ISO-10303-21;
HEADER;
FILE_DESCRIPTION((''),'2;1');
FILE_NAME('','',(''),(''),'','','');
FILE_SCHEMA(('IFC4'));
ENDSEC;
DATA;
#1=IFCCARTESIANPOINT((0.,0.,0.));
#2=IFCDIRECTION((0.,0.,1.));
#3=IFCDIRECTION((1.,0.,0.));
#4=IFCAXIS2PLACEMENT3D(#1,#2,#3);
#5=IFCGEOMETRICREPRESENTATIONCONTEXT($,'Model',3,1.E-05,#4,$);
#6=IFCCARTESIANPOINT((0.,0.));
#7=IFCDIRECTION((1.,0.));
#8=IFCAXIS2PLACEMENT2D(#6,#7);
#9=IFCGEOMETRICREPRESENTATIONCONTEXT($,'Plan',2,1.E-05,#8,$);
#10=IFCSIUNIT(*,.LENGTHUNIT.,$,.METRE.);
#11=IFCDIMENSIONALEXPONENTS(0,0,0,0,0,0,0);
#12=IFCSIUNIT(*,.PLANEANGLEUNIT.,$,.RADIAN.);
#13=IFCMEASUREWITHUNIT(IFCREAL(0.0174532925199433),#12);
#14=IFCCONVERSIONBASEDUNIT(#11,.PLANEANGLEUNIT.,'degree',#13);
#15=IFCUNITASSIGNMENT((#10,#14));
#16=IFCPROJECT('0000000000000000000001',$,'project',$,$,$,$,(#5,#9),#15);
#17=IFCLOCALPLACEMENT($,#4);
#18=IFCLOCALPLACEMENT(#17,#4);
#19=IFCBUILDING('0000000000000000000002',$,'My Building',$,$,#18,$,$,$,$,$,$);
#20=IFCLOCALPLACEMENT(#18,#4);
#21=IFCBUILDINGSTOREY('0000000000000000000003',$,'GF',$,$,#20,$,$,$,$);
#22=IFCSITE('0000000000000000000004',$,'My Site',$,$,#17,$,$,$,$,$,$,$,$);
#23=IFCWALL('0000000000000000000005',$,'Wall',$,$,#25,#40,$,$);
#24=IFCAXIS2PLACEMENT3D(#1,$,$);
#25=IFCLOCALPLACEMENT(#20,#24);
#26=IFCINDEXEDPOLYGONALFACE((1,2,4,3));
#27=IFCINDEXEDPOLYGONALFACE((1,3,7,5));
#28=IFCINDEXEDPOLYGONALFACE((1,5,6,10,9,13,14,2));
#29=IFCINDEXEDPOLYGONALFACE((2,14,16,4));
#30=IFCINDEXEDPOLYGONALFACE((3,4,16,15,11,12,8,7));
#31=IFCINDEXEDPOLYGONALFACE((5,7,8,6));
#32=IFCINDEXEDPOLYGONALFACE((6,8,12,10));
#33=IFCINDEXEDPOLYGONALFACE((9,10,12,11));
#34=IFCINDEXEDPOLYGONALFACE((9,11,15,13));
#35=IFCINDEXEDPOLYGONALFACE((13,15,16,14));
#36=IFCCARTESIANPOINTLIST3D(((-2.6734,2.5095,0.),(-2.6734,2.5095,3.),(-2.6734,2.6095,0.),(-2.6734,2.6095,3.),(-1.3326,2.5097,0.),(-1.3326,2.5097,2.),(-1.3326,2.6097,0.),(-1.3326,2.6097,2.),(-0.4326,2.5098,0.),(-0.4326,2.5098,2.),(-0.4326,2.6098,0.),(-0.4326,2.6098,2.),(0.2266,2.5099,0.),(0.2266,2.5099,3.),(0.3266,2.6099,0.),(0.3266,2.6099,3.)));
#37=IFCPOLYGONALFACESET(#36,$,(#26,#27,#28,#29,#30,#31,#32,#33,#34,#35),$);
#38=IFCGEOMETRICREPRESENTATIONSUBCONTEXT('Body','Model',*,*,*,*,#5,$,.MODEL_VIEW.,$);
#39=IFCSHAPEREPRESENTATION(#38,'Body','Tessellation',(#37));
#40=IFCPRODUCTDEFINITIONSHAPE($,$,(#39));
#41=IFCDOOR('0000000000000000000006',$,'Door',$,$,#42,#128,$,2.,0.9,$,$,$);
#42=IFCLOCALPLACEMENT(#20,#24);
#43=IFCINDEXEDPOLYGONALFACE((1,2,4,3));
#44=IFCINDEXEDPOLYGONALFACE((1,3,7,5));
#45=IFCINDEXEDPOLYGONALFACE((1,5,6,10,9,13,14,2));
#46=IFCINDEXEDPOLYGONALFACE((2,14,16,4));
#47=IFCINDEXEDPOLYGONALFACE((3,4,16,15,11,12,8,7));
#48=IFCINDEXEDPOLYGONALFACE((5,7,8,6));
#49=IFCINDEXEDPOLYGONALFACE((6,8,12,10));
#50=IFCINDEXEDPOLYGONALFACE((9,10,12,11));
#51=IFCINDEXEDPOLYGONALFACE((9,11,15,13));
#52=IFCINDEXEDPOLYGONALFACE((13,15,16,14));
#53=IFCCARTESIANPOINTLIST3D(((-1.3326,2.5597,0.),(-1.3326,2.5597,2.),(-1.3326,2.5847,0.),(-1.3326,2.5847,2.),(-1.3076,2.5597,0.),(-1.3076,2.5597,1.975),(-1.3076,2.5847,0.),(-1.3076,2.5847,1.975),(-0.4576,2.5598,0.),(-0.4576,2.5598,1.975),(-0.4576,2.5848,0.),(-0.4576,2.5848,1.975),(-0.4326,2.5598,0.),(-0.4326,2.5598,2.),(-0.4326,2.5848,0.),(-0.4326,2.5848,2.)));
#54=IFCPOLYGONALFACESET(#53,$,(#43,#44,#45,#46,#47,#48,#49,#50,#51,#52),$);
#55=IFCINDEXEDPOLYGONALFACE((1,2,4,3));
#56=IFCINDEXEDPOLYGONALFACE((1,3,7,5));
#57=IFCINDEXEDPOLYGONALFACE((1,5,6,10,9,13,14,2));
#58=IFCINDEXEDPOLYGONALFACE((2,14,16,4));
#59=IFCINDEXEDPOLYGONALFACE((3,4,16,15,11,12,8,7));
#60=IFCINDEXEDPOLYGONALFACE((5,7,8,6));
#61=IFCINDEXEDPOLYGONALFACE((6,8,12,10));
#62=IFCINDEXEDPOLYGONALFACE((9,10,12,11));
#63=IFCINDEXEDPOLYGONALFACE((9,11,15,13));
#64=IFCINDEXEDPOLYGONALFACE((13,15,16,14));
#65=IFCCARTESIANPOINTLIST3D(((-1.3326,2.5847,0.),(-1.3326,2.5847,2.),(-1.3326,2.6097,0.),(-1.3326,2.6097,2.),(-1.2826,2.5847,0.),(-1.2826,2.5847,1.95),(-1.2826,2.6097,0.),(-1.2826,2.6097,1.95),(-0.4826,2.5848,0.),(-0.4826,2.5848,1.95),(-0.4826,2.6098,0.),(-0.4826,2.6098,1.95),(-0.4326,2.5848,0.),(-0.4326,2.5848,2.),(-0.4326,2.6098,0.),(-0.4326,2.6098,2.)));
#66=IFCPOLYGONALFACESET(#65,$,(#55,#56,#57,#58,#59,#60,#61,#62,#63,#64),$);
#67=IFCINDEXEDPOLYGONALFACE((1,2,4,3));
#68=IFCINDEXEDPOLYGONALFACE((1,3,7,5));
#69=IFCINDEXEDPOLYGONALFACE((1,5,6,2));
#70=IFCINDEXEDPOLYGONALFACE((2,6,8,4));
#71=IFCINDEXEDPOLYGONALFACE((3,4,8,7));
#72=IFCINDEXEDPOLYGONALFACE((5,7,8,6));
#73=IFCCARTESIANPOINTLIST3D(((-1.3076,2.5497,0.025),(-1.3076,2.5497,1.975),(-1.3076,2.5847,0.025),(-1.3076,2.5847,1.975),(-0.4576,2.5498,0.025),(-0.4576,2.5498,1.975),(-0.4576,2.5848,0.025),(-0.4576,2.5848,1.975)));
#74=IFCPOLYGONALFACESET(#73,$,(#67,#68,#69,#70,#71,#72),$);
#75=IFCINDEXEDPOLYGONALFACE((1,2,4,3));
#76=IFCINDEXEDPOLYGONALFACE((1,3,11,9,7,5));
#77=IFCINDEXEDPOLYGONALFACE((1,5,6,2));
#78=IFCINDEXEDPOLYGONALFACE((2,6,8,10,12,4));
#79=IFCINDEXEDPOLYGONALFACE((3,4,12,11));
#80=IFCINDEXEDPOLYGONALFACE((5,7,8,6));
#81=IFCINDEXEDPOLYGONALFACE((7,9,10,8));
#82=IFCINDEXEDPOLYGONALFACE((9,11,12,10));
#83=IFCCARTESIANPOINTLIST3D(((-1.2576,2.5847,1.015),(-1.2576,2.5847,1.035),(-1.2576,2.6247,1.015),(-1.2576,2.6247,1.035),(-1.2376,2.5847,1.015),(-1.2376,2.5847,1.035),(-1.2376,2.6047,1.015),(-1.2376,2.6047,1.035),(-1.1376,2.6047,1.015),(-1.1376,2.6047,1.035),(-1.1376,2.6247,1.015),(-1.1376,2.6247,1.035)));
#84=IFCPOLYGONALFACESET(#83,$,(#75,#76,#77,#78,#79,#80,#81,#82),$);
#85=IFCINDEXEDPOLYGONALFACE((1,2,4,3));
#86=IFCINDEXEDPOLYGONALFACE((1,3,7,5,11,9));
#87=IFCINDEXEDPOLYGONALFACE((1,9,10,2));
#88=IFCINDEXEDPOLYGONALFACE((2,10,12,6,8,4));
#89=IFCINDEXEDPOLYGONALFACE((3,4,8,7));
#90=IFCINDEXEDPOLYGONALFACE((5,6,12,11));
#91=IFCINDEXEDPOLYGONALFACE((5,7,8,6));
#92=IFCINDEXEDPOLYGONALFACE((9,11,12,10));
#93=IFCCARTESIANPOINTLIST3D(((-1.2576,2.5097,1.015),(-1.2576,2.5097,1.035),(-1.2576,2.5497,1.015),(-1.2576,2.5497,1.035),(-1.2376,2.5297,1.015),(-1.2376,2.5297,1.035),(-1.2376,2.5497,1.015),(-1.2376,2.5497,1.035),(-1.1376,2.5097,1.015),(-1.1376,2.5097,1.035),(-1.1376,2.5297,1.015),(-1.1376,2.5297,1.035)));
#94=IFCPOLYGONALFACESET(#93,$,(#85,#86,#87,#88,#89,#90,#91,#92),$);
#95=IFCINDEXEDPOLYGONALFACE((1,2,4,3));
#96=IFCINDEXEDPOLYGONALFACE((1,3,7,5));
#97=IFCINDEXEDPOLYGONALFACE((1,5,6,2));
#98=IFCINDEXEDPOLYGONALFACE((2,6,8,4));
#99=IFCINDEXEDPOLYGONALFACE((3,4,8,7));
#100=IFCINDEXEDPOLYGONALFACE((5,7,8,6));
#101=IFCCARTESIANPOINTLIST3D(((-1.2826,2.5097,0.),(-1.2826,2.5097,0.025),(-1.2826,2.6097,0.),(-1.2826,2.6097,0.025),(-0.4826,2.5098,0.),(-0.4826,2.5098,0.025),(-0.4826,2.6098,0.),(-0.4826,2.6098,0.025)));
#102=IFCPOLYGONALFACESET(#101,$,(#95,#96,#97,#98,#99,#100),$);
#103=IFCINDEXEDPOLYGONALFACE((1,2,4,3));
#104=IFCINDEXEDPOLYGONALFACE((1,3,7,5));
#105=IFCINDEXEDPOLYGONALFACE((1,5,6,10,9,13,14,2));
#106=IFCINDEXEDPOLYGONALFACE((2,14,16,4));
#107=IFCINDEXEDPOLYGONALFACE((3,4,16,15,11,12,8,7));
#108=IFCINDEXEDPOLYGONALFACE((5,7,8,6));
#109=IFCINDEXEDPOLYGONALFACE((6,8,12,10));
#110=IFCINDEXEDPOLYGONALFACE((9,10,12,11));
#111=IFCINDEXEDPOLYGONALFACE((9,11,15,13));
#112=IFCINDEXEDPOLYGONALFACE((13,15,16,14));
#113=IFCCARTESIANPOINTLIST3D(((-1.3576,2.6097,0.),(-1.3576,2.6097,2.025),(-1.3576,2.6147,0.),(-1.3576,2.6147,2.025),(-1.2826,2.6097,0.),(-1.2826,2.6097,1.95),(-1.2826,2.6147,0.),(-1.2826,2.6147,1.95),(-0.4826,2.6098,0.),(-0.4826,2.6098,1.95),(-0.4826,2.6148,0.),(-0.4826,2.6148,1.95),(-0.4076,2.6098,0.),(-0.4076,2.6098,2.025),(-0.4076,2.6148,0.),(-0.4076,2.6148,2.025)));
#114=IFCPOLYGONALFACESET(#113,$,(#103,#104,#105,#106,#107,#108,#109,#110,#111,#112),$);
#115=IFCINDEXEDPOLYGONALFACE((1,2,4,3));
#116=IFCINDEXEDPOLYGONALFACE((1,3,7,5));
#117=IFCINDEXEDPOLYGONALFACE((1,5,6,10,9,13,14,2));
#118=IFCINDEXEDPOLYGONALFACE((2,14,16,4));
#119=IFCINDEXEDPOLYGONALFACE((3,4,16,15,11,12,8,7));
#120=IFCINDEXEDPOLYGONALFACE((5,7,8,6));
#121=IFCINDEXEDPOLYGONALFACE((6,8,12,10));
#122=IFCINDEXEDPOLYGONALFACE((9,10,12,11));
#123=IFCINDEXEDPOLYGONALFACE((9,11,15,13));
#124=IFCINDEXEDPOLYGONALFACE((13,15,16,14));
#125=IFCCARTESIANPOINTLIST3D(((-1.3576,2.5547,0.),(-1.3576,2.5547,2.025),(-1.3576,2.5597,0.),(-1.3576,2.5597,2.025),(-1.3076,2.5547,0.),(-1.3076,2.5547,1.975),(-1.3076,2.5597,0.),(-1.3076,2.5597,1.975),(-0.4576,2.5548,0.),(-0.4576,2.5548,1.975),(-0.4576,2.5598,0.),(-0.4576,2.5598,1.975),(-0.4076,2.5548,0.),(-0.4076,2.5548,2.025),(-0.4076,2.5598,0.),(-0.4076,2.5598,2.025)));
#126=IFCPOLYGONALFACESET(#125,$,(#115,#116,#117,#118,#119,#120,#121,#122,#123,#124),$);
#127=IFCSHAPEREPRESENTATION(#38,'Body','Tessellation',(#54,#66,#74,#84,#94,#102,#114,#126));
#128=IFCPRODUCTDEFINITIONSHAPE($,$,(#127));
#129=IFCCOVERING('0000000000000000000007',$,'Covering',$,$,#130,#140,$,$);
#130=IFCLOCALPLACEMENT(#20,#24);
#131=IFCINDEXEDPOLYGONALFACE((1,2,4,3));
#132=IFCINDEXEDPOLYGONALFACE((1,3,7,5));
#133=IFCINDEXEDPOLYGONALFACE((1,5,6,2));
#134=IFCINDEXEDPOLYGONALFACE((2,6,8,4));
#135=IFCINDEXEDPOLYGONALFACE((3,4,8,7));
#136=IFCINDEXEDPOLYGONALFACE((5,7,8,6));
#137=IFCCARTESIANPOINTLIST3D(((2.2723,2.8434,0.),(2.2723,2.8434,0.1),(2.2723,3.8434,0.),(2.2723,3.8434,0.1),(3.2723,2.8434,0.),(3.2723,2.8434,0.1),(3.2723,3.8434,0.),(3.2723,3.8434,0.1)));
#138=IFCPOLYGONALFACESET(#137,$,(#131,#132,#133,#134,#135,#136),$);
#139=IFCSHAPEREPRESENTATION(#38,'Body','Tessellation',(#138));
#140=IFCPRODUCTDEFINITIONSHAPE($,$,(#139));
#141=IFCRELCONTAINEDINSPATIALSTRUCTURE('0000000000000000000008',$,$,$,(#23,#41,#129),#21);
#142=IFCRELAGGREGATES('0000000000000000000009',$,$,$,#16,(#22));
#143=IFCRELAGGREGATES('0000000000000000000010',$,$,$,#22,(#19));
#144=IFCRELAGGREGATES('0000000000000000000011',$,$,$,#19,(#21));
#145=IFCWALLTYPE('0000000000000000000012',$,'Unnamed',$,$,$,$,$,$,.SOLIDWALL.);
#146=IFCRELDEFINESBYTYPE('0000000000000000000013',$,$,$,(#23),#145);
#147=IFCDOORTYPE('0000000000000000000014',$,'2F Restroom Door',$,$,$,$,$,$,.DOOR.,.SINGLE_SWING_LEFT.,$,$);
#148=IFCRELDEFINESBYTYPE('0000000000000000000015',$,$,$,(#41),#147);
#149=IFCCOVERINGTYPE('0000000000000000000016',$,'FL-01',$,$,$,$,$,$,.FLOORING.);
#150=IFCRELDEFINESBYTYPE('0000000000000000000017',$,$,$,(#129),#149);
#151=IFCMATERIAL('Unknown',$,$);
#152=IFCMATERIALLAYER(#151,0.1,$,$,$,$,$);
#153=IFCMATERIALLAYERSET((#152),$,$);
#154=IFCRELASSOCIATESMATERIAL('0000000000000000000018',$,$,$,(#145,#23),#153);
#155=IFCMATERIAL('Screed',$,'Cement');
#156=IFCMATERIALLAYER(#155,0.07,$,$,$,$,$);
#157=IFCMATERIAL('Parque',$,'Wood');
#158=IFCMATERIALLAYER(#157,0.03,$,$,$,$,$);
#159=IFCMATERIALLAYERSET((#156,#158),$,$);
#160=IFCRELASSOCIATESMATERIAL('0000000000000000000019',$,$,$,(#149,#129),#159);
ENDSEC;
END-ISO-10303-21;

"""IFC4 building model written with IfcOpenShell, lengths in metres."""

from ifc_helpers import new_model, entity, si_unit, converted_unit, frame, origin_with_axes, origin_2d_with_axis, place, context, subcontext, project, spatial, line, indexed_curve, outline, extrude, shape, source, transform, mapped, material, layer, layer_set, layer_usage, type_object, type_shapes, element, fill, save


model = new_model("IFC4")

# Units and contexts
model_context = context("Model", 3, precision=1e-05, world=origin_with_axes())
plan_context = context("Plan", 2, precision=1e-05, world=origin_2d_with_axis())
body_context_1 = subcontext(model_context, "Body", "Model", "MODEL_VIEW")
body_context_2 = subcontext(plan_context, "Body", "Plan", "PLAN_VIEW")
ifc_project = project(units=[si_unit("LENGTHUNIT", "METRE"), converted_unit("PLANEANGLEUNIT", "degree", entity("IfcReal", 0.0174532925199433), si_unit("PLANEANGLEUNIT", "RADIAN"), dimensions=[0, 0, 0, 0, 0, 0, 0])], contexts=[model_context, plan_context])

# Site, building, storey
site_placement = place(None, origin_with_axes())
site = spatial("IfcSite", under=ifc_project, at=site_placement, Name="My Site")
building_placement = place(site_placement, origin_with_axes())
building = spatial("IfcBuilding", under=site, at=building_placement, Name="My Building")
storey_placement = place(building_placement, origin_with_axes())
storey = spatial("IfcBuildingStorey", under=building, at=storey_placement, Name="GF")

# Shared definitions
ifc_material_1 = material(Name="Unknown")

# Shared definitions
ifc_layer_1 = layer(ifc_material_1, 0.1)
ifc_layer_set_1 = layer_set([ifc_layer_1])
wall_type = type_object("IfcWallType", Name="Unnamed", PredefinedType="SOLIDWALL", material=ifc_layer_set_1)

# Wall, opening, door
ifc_layer_usage_1 = layer_usage(ifc_layer_set_1, "AXIS2", "POSITIVE", 0.0)
wall_1_placement = place(storey_placement, frame((0.3266, 2.6099, 0.0), z_axis=(0.0, 0.0, 1.0), x_axis=(-1.0, -0.00012, 0.0)))
wall_1 = element("IfcWall", 1, at=wall_1_placement, inside=storey, type_object=wall_type, material=ifc_layer_usage_1, Name="Wall", context=body_context_1, shape_type="SweptSolid", body=[
    extrude(outline(indexed_curve([(0.0, 0.0), (0.1, 0.1), (3.0, 0.1), (3.0, 0.0)], segments=[line(1, 2, 3, 4, 1)])), origin_with_axes(), (0.0, 0.0, 1.0), 3.0),
])
shared_shape_1 = source(origin_with_axes(), body_context_1, "Body", "SweptSolid", [
    extrude(outline(indexed_curve([(0.0, 0.0), (0.9, 0.0), (0.9, 2.0), (0.0, 2.0)], segments=[line(1, 2, 3, 4, 1)])), frame((0.0, -0.6, 0.0), z_axis=(0.0, -1.0, 0.0), x_axis=(1.0, 0.0, 0.0)), (0.0, 0.0, -1.0), 1.2),
])
opening_1_placement = place(wall_1_placement, frame((0.7592, 0.0, 0.0), z_axis=(0.0, 0.0, 1.0), x_axis=(1.0, 0.0, 0.0)))
opening_1 = element("IfcOpeningElement", 2, at=opening_1_placement, cuts=wall_1, PredefinedType="OPENING", context=body_context_1, shape_type="MappedRepresentation", body=[
    mapped(shared_shape_1, transform((0.0, 0.0, 0.0), x_axis=(1.0, 0.0, 0.0), y_axis=(0.0, 1.0, 0.0), z_axis=(0.0, 0.0, 1.0), scale=1.0)),
])
door_type_1 = type_object("IfcDoorType", Name="2F Restroom Door", OperationType="SINGLE_SWING_LEFT", PredefinedType="DOOR")
shared_shape_2 = source(origin_with_axes(), body_context_1, "Body", "SweptSolid", [
    extrude(outline(indexed_curve([(0.0, 0.0), (0.0, 2.0), (0.9, 2.0), (0.9, 0.0), (0.875, 0.0), (0.875, 1.975), (0.025, 1.975), (0.025, 0.0)], segments=[line(1, 2, 3, 4, 5, 6, 7, 8, 1)])), frame((0.0, 0.025, 0.0), z_axis=(0.0, -1.0, 0.0), x_axis=(1.0, 0.0, 0.0)), (0.0, 0.0, -1.0), 0.025),
    extrude(outline(indexed_curve([(0.0, 0.0), (0.0, 2.0), (0.9, 2.0), (0.9, 0.0), (0.85, 0.0), (0.85, 1.95), (0.05, 1.95), (0.05, 0.0)], segments=[line(1, 2, 3, 4, 5, 6, 7, 8, 1)])), frame((0.0, 0.0, 0.0), z_axis=(0.0, -1.0, 0.0), x_axis=(1.0, 0.0, 0.0)), (0.0, 0.0, -1.0), 0.025),
    extrude(outline(indexed_curve([(0.0, 0.0), (0.85, 0.0), (0.85, 0.035), (0.0, 0.035)], segments=[line(1, 2, 3, 4, 1)])), frame((0.025, 0.025, 0.025), z_axis=(0.0, 0.0, 1.0), x_axis=(1.0, 0.0, 0.0)), (0.0, 0.0, 1.0), 1.95),
    extrude(outline(indexed_curve([(0.0, 0.0), (0.0, -0.04), (-0.12, -0.04), (-0.12, -0.02), (-0.02, -0.02), (-0.02, 0.0)], segments=[line(1, 2, 3, 4, 5, 6, 1)])), frame((0.825, 0.025, 1.015), z_axis=(0.0, 0.0, 1.0), x_axis=(1.0, 0.0, 0.0)), (0.0, 0.0, 1.0), 0.02),
    extrude(outline(indexed_curve([(0.0, 0.0), (0.0, 0.04), (-0.12, 0.04), (-0.12, 0.02), (-0.02, 0.02), (-0.02, 0.0)], segments=[line(1, 2, 3, 4, 5, 6, 1)])), frame((0.825, 0.06, 1.015), z_axis=(0.0, 0.0, 1.0), x_axis=(1.0, 0.0, 0.0)), (0.0, 0.0, 1.0), 0.02),
    extrude(outline(indexed_curve([(0.0, 0.0), (0.8, 0.0), (0.8, 0.1), (0.0, 0.1)], segments=[line(1, 2, 3, 4, 1)])), frame((0.05, 0.0, 0.0), z_axis=(0.0, 0.0, 1.0), x_axis=(1.0, 0.0, 0.0)), (0.0, 0.0, 1.0), 0.025),
    extrude(outline(indexed_curve([(0.0, 0.0), (0.0, 2.025), (0.95, 2.025), (0.95, 0.0), (0.875, 0.0), (0.875, 1.95), (0.075, 1.95), (0.075, 0.0)], segments=[line(1, 2, 3, 4, 5, 6, 7, 8, 1)])), frame((-0.025, -0.005, 0.0), z_axis=(0.0, -1.0, 0.0), x_axis=(1.0, 0.0, 0.0)), (0.0, 0.0, -1.0), 0.005),
    extrude(outline(indexed_curve([(0.0, 0.0), (0.0, 2.025), (0.95, 2.025), (0.95, 0.0), (0.9, 0.0), (0.9, 1.975), (0.05, 1.975), (0.05, 0.0)], segments=[line(1, 2, 3, 4, 5, 6, 7, 8, 1)])), frame((-0.025, 0.05, 0.0), z_axis=(0.0, -1.0, 0.0), x_axis=(1.0, 0.0, 0.0)), (0.0, 0.0, -1.0), 0.005),
])
shared_shape_3 = source(origin_with_axes(), body_context_2, "Body", "Curve2D", [
    entity("IfcIndexedPolyCurve", entity("IfcCartesianPointList2D", [[0.0, 0.0], [0.0, 0.05], [0.025, 0.05], [0.025, 0.025], [0.05, 0.025], [0.05, 0.0]]), [entity("IfcLineIndex", [1, 2, 3, 4, 5, 6, 1])]),
    entity("IfcIndexedPolyCurve", entity("IfcCartesianPointList2D", [[0.9, 0.0], [0.9, 0.05], [0.875, 0.05], [0.875, 0.025], [0.85, 0.025], [0.85, 0.0]]), [entity("IfcLineIndex", [1, 2, 3, 4, 5, 6, 1])]),
    entity("IfcTrimmedCurve", entity("IfcEllipse", entity("IfcAxis2Placement2D", entity("IfcCartesianPoint", [0.06, 0.05]), entity("IfcDirection", [1.0, 0.0])), 0.815, 0.85), [entity("IfcCartesianPoint", [0.875, 0.05])], [entity("IfcCartesianPoint", [0.06, 0.9])], True, "CARTESIAN"),
    entity("IfcIndexedPolyCurve", entity("IfcCartesianPointList2D", [[0.025, 0.05], [0.06, 0.05], [0.06, 0.9], [0.025, 0.9]]), [entity("IfcLineIndex", [1, 2, 3, 4, 1])]),
])
type_shapes(door_type_1, [shared_shape_2, shared_shape_3])
door_1_placement = place(opening_1_placement, frame((0.0, 0.0, 0.0), z_axis=(0.0, 0.0, 1.0), x_axis=(1.0, 0.0, 0.0)))
door_1 = element("IfcDoor", 3, at=door_1_placement, inside=storey, type_object=door_type_1, Name="Door", OverallHeight=2.0, OverallWidth=0.9, shapes=[
    shape(body_context_1, "Body", "MappedRepresentation", [mapped(shared_shape_2, transform((0.0, 0.0, 0.0), x_axis=(1.0, 0.0, 0.0), y_axis=(0.0, 1.0, 0.0), z_axis=(0.0, 0.0, 1.0), scale=1.0))]),
    shape(body_context_2, "Body", "MappedRepresentation", [mapped(shared_shape_3, transform((0.0, 0.0, 0.0), x_axis=(1.0, 0.0, 0.0), y_axis=(0.0, 1.0, 0.0), z_axis=(0.0, 0.0, 1.0), scale=1.0))]),
])
fill(opening_1, door_1)

# Covering
ifc_material_2 = material(Name="Screed", Category="Cement")
ifc_layer_2 = layer(ifc_material_2, 0.07)
ifc_material_3 = material(Name="Parque", Category="Wood")
ifc_layer_3 = layer(ifc_material_3, 0.03)
ifc_layer_set_2 = layer_set([ifc_layer_2, ifc_layer_3])
ifc_layer_usage_2 = layer_usage(ifc_layer_set_2, "AXIS3", "POSITIVE", 0.0)
covering_type = type_object("IfcCoveringType", Name="FL-01", PredefinedType="FLOORING", material=ifc_layer_set_2)
covering_placement = place(storey_placement, frame((2.2723, 2.8434, 0.0), z_axis=(0.0, 0.0, 1.0), x_axis=(1.0, 0.0, 0.0)))
element("IfcCovering", 4, at=covering_placement, inside=storey, type_object=covering_type, material=ifc_layer_usage_2, Name="Covering", context=body_context_1, shape_type="SweptSolid", body=[
    extrude(outline(indexed_curve([(0.0, 0.0), (1.0, 0.0), (1.0, 1.0), (0.0, 1.0), (0.0, 0.0)])), None, (0.0, 0.0, 1.0), 0.1),
])

save(model, "model.ifc")
